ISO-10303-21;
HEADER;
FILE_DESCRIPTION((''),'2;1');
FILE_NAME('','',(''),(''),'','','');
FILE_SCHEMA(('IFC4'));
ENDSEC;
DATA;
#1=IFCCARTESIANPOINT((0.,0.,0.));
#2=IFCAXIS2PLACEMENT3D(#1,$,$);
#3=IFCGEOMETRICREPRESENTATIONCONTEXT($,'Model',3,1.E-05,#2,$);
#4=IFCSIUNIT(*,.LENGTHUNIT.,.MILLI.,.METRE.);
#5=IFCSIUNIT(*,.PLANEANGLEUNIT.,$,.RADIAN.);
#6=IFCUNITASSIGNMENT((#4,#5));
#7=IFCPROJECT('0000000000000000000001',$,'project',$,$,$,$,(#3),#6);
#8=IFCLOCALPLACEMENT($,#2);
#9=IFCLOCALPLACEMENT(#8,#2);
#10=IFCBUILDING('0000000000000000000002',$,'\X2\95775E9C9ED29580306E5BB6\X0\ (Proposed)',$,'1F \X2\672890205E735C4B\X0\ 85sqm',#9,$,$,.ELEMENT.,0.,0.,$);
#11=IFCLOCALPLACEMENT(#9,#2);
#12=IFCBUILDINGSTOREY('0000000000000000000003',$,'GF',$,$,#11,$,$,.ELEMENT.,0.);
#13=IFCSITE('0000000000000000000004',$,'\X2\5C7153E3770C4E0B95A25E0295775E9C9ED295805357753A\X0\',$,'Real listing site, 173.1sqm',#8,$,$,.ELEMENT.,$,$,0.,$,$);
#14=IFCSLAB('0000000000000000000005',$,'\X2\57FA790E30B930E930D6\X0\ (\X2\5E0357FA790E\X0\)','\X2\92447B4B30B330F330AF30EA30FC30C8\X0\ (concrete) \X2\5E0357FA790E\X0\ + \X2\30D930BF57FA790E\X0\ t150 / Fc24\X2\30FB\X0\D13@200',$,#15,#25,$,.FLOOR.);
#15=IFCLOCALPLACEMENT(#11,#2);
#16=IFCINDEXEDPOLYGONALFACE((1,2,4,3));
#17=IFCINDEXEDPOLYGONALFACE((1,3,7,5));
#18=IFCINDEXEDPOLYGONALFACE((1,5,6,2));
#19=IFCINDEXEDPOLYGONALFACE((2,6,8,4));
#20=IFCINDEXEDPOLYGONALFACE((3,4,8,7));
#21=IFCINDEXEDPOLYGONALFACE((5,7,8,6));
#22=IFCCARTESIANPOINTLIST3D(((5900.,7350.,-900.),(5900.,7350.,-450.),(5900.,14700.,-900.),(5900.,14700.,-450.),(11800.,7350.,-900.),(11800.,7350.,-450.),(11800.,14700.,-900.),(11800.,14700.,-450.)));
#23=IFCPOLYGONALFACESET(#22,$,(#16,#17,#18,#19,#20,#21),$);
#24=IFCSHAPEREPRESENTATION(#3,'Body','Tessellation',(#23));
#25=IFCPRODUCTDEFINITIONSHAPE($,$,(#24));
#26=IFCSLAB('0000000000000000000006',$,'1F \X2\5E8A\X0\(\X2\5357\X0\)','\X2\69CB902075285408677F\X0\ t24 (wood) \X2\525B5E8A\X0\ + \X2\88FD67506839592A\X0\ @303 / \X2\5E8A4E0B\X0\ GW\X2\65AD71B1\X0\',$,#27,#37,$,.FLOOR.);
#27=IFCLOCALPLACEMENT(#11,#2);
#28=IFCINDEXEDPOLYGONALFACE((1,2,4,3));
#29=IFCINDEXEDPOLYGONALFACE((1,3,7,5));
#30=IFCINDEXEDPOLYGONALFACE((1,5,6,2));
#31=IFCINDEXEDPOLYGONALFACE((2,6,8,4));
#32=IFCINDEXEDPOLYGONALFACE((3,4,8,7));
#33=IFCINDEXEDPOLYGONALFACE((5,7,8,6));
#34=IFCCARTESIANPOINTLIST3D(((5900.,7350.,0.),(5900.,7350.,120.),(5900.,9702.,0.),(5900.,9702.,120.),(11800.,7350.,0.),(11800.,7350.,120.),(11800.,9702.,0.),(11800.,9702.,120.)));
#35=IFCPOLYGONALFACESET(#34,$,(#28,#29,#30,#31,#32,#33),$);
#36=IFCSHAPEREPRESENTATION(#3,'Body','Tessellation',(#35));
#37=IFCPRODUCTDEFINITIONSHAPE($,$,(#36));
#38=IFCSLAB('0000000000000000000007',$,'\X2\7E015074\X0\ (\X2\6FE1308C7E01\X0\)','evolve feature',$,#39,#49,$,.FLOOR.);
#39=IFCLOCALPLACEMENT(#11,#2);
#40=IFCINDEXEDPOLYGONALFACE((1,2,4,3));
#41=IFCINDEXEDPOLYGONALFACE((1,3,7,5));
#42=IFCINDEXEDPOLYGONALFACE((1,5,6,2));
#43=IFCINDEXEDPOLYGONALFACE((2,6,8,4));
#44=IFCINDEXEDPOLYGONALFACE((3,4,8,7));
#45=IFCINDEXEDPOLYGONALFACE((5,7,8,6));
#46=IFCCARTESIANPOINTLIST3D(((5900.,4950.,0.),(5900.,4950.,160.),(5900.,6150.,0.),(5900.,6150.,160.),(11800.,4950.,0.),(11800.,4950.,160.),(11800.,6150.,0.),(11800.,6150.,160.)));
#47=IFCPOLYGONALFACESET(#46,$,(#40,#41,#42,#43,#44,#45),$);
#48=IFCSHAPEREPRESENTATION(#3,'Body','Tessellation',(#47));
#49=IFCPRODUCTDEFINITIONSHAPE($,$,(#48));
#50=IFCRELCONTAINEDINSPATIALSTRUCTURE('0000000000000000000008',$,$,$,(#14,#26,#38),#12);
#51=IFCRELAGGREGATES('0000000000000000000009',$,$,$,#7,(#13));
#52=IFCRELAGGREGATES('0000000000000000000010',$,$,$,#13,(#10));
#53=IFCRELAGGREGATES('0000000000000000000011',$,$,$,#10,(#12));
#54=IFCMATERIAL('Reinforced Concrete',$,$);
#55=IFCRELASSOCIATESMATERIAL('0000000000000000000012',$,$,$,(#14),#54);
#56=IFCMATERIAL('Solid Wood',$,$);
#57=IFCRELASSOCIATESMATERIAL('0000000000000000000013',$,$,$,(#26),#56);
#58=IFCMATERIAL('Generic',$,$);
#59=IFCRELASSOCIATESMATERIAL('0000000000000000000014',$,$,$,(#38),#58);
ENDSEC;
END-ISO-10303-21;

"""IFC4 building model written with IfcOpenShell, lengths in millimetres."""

from ifc_helpers import new_model, si_unit, frame, frame_2d, origin, place, context, project, spatial, rectangle, extrude, material, element, save


model = new_model("IFC4")

# Units and contexts
model_context = context("Model", 3, precision=1e-05, world=origin())
ifc_project = project(units=[si_unit("LENGTHUNIT", "METRE", prefix="MILLI"), si_unit("PLANEANGLEUNIT", "RADIAN")], contexts=[model_context])

# Site, building, storey
site_placement = place(None, origin())
site = spatial("IfcSite", under=ifc_project, at=site_placement, Name="山口県下関市長府黒門南町", ObjectType="Real listing site, 173.1sqm", CompositionType="ELEMENT", RefElevation=0.0)
building_placement = place(site_placement, origin())
building = spatial("IfcBuilding", under=site, at=building_placement, Name="長府黒門の家 (Proposed)", ObjectType="1F 木造平屋 85sqm", CompositionType="ELEMENT", ElevationOfRefHeight=0.0, ElevationOfTerrain=0.0)
storey_placement = place(building_placement, origin())
storey = spatial("IfcBuildingStorey", under=building, at=storey_placement, Name="GF", CompositionType="ELEMENT", Elevation=0.0)

# Slabs
ifc_material_1 = material(Name="Reinforced Concrete")
slab_1_placement = place(storey_placement, frame((2950.0, 3675.0, -450.0)))
element("IfcSlab", 1, at=slab_1_placement, inside=storey, material=ifc_material_1, Name="基礎スラブ (布基礎)", Description="鉄筋コンクリート (concrete) 布基礎 + ベタ基礎 t150 / Fc24・D13@200", PredefinedType="FLOOR", context=model_context, shape_type="SweptSolid", body=[
    extrude(rectangle(XDim=5900.0, YDim=7350.0, at=frame_2d((2950.0, 3675.0))), frame((2950.0, 3675.0, -450.0)), (0.0, 0.0, 1.0), 450.0),
])
ifc_material_2 = material(Name="Solid Wood")
slab_2_placement = place(storey_placement, frame((2950.0, 3675.0, 0.0)))
element("IfcSlab", 2, at=slab_2_placement, inside=storey, material=ifc_material_2, Name="1F 床(南)", Description="構造用合板 t24 (wood) 剛床 + 製材根太 @303 / 床下 GW断熱", PredefinedType="FLOOR", context=model_context, shape_type="SweptSolid", body=[
    extrude(rectangle(XDim=5900.0, YDim=2352.0, at=frame_2d((2950.0, 1176.0))), frame((2950.0, 3675.0, 0.0)), (0.0, 0.0, 1.0), 120.0),
])
ifc_material_3 = material(Name="Generic")
slab_3_placement = place(storey_placement, frame((2950.0, 2475.0, 0.0)))
element("IfcSlab", 3, at=slab_3_placement, inside=storey, material=ifc_material_3, Name="縁側 (濡れ縁)", Description="evolve feature", PredefinedType="FLOOR", context=model_context, shape_type="SweptSolid", body=[
    extrude(rectangle(XDim=5900.0, YDim=1200.0, at=frame_2d((2950.0, 600.0))), frame((2950.0, 2475.0, 0.0)), (0.0, 0.0, 1.0), 160.0),
])

save(model, "model.ifc")
